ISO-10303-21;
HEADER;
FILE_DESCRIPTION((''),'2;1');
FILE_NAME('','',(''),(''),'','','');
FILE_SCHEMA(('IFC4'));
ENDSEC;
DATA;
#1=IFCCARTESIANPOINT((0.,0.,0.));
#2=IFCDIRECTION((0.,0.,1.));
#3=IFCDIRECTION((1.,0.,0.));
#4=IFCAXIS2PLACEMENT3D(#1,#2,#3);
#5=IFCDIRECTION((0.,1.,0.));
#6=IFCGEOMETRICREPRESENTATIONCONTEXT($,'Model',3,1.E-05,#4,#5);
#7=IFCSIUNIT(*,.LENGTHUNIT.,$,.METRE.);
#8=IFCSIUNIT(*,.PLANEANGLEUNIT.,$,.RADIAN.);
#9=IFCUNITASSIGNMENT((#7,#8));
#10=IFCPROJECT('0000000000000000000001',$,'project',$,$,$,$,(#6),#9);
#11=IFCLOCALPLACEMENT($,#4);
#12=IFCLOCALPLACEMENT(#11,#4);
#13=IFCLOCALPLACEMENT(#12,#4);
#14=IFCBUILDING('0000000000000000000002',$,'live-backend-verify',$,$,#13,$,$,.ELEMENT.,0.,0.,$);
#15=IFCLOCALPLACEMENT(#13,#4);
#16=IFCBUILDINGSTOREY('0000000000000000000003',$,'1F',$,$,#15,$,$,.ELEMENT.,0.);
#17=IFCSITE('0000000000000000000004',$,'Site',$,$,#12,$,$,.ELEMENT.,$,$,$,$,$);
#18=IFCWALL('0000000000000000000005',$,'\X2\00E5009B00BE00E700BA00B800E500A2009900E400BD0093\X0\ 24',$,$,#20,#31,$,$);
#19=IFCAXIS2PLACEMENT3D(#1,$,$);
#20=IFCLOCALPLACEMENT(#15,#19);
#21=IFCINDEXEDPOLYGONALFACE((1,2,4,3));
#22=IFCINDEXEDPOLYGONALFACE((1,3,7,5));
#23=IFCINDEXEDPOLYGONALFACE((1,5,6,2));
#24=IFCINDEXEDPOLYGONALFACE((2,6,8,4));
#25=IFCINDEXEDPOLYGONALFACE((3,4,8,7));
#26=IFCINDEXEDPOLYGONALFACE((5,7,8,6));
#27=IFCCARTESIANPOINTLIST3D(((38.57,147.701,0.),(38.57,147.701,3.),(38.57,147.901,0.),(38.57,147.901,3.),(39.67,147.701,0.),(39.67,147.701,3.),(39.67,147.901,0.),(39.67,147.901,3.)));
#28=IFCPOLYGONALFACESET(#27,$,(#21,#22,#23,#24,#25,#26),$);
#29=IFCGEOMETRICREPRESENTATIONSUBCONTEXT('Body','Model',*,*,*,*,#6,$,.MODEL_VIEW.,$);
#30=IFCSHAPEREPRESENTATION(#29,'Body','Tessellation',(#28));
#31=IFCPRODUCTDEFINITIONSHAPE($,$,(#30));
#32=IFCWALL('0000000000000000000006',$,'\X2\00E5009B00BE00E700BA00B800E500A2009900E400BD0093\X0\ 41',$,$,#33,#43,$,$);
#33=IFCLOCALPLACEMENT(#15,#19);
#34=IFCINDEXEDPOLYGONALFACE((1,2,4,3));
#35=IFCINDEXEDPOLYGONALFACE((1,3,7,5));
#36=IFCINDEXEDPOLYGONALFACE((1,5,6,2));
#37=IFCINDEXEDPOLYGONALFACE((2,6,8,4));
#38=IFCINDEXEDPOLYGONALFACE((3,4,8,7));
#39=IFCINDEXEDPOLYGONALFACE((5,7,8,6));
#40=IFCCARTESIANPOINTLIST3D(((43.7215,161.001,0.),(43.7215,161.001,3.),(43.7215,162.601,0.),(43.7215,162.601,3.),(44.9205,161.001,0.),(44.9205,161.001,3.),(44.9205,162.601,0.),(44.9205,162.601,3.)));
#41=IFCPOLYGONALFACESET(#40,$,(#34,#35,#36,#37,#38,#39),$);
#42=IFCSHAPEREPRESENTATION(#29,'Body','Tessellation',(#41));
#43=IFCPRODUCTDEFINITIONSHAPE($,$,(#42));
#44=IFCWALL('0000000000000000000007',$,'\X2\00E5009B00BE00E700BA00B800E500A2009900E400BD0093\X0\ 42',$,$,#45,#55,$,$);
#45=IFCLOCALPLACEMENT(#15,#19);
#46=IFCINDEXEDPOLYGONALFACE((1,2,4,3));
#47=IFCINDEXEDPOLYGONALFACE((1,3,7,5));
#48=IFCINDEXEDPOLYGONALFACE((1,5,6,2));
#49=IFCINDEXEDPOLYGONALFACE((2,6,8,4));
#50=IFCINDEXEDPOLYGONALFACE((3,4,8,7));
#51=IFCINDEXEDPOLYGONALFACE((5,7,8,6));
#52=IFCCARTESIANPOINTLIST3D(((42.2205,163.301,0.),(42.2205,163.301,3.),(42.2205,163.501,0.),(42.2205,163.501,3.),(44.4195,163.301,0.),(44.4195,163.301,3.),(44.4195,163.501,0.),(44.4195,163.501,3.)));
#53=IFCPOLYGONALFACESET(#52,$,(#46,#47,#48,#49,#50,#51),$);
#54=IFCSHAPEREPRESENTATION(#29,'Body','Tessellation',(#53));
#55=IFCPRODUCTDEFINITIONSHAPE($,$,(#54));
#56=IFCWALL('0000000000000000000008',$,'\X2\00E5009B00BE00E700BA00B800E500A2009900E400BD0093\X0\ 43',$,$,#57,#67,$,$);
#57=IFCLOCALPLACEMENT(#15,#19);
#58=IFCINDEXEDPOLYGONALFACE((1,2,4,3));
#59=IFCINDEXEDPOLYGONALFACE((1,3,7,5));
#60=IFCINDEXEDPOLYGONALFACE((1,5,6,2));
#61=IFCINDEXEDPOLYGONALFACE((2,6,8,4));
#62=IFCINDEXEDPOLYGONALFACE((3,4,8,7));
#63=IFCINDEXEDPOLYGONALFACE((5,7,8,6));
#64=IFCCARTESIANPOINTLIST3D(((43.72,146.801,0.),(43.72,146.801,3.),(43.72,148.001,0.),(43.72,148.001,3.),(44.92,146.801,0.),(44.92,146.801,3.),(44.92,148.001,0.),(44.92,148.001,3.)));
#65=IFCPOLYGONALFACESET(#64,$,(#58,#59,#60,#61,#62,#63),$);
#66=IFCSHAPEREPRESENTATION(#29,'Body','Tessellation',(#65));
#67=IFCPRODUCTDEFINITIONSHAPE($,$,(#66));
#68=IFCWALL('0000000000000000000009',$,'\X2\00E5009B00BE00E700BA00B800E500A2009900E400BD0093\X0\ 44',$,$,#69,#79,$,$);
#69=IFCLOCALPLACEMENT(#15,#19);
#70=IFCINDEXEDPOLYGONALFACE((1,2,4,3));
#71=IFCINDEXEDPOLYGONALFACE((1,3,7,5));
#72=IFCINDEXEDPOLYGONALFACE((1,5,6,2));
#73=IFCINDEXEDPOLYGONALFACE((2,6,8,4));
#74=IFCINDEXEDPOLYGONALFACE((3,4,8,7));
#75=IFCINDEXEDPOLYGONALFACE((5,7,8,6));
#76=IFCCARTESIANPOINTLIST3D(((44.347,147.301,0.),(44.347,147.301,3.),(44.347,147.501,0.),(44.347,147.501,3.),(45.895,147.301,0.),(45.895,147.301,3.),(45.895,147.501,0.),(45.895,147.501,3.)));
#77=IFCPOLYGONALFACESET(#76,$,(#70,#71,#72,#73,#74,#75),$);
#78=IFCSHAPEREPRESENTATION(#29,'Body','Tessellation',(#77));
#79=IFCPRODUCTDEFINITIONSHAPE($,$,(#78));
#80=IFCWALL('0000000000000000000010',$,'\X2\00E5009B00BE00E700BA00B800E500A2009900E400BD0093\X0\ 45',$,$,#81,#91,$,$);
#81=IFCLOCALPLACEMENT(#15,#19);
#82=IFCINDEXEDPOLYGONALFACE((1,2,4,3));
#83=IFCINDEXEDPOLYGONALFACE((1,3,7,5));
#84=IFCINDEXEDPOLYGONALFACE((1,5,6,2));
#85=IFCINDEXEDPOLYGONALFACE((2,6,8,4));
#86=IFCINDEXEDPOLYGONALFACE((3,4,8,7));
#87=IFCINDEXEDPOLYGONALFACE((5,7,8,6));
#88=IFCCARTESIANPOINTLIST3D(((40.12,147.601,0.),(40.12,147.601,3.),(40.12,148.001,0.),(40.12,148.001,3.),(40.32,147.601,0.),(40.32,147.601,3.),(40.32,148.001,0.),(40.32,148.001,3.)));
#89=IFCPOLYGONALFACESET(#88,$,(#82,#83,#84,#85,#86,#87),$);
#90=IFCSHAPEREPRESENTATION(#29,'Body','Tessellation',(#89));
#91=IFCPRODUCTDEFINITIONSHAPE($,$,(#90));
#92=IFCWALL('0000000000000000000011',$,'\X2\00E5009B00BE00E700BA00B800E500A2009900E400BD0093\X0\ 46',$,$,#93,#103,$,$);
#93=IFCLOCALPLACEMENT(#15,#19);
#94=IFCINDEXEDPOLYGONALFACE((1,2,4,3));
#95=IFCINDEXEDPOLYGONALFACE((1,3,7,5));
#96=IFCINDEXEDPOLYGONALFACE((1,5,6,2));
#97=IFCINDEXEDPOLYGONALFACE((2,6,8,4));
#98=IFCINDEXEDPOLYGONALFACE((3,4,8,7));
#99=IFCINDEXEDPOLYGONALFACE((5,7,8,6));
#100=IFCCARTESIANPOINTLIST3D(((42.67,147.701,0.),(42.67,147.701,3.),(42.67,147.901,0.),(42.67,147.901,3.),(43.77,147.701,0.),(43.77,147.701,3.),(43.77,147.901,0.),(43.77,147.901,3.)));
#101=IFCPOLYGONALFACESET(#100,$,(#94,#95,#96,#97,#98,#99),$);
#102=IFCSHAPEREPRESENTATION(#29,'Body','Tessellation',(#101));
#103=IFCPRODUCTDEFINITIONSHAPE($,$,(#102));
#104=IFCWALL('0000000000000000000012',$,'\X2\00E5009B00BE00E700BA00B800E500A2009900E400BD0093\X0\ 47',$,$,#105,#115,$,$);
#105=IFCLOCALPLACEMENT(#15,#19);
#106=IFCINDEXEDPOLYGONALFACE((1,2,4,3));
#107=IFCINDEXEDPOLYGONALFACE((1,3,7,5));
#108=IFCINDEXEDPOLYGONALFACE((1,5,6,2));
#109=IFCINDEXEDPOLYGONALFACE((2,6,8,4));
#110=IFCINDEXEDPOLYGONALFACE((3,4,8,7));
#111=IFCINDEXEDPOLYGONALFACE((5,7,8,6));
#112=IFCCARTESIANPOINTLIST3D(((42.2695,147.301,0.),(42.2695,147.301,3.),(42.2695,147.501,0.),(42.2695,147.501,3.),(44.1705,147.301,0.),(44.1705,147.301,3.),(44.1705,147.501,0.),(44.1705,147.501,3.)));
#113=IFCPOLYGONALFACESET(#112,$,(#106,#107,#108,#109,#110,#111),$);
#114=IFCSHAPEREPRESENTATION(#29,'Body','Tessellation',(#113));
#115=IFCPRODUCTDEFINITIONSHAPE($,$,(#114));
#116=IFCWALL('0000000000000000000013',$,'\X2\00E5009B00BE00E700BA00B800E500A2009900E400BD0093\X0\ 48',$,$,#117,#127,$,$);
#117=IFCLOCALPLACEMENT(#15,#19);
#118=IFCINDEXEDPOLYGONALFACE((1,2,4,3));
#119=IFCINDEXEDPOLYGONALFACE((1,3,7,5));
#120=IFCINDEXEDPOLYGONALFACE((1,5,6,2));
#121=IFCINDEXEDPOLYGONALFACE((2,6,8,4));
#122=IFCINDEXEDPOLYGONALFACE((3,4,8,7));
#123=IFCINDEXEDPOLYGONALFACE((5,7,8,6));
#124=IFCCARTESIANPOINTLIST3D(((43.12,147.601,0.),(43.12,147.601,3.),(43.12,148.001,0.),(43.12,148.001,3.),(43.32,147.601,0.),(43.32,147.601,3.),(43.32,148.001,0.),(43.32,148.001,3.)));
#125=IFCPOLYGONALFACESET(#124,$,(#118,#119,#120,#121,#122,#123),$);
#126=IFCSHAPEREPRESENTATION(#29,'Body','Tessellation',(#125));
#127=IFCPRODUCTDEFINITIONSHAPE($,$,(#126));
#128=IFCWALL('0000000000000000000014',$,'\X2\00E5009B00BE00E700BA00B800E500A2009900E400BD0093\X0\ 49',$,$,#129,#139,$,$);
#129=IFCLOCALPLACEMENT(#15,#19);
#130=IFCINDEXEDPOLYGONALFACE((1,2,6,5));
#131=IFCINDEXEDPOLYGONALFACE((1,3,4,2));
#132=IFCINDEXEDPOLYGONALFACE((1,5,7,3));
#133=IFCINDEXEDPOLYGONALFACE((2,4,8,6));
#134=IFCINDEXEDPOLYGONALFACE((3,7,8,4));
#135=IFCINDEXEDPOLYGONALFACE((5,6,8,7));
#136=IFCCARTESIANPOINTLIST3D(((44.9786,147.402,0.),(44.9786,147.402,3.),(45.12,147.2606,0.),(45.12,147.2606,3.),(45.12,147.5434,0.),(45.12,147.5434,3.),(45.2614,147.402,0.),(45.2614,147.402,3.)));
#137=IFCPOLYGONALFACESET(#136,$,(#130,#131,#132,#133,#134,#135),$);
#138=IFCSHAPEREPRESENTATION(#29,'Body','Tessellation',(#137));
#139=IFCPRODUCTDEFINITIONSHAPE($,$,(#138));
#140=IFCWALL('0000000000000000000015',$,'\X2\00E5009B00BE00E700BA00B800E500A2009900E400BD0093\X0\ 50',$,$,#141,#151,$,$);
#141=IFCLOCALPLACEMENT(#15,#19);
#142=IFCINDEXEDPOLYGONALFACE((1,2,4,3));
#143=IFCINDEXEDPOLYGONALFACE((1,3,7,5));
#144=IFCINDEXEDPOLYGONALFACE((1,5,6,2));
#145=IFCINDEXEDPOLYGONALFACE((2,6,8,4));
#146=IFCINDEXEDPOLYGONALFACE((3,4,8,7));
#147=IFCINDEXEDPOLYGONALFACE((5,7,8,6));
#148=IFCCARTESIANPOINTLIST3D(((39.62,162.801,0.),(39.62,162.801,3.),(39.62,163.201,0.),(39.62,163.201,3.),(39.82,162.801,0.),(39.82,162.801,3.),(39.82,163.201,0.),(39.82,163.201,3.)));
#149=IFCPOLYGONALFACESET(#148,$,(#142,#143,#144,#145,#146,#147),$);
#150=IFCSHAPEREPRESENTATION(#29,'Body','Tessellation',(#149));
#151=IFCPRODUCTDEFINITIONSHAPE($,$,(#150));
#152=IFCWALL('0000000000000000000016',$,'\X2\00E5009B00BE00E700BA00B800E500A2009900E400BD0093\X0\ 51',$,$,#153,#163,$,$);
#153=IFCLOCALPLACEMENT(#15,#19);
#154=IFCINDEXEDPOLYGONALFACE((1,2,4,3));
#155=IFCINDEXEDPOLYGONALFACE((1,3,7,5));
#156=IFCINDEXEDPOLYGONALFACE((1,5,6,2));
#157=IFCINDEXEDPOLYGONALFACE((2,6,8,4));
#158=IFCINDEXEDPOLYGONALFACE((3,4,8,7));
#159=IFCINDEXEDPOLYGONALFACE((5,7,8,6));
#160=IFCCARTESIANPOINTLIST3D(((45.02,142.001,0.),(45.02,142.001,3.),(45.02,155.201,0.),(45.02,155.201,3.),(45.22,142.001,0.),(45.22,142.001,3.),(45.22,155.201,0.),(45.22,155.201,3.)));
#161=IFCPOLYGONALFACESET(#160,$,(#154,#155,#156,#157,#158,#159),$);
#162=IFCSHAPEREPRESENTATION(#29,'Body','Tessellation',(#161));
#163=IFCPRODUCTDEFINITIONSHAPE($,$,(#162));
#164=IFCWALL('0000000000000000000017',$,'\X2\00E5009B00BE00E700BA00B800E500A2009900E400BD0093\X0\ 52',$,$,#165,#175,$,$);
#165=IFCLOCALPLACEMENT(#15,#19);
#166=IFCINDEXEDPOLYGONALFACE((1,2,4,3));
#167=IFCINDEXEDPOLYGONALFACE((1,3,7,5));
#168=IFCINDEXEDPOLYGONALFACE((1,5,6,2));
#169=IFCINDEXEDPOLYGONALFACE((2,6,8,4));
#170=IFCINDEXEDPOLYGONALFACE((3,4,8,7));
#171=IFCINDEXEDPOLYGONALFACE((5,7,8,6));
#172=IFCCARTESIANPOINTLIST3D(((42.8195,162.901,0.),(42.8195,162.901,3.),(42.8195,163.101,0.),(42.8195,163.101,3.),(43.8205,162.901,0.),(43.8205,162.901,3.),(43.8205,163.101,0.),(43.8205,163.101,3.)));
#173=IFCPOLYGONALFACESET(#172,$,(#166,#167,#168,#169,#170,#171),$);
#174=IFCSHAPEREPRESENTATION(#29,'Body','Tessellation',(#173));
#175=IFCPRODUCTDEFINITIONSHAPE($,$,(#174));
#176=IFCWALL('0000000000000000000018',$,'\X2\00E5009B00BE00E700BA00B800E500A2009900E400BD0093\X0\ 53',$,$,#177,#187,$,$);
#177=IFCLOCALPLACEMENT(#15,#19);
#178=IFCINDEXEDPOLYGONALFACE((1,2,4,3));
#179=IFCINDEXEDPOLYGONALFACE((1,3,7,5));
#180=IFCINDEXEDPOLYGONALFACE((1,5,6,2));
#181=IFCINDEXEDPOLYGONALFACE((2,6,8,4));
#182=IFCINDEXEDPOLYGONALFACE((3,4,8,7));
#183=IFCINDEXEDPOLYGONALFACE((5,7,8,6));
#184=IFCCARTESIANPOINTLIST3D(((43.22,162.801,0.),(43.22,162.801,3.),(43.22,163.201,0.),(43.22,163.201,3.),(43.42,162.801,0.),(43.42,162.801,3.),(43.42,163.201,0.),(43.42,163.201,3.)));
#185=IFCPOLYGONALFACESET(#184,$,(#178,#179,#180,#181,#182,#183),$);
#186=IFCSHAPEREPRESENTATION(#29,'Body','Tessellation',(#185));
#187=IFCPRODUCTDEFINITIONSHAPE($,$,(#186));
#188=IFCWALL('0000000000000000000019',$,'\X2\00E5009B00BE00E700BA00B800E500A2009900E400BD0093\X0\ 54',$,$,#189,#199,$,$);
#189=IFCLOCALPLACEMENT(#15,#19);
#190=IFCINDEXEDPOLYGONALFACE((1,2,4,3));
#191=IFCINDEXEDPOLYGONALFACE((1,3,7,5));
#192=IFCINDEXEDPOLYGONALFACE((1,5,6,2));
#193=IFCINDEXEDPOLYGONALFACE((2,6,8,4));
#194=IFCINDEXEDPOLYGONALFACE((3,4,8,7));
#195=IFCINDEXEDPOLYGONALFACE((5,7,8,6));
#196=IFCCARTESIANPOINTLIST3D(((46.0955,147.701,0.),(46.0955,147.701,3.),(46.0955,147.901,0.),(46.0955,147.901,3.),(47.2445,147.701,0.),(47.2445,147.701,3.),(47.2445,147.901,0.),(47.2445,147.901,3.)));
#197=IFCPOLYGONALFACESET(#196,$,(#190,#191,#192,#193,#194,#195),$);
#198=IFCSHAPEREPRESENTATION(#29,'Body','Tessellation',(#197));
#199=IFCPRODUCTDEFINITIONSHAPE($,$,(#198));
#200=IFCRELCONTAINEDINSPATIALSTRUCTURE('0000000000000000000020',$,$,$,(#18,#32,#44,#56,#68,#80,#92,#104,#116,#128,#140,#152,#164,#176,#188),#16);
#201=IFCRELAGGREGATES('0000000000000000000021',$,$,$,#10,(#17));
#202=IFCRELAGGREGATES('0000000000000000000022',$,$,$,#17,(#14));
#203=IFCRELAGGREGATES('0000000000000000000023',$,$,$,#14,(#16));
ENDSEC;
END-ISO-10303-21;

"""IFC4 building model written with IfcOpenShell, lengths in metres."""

from ifc_helpers import new_model, si_unit, direction, frame, frame_2d, origin_with_axes, place, context, subcontext, project, spatial, rectangle, extrude, element, save


model = new_model("IFC4")

# Units and contexts
model_context = context("Model", 3, precision=1e-05, world=origin_with_axes(), true_north=direction((0.0, 1.0, 0.0)))
body_context = subcontext(model_context, "Body", "Model", "MODEL_VIEW")
ifc_project = project(units=[si_unit("LENGTHUNIT", "METRE"), si_unit("PLANEANGLEUNIT", "RADIAN")], contexts=[model_context])

# Site, building, storey
placement = place(None, origin_with_axes())
site_placement = place(placement, origin_with_axes())
site = spatial("IfcSite", under=ifc_project, at=site_placement, Name="Site", CompositionType="ELEMENT")
building_placement = place(site_placement, origin_with_axes())
building = spatial("IfcBuilding", under=site, at=building_placement, Name="live-backend-verify", CompositionType="ELEMENT", ElevationOfRefHeight=0.0, ElevationOfTerrain=0.0)
storey_placement = place(building_placement, origin_with_axes())
storey = spatial("IfcBuildingStorey", under=building, at=storey_placement, Name="1F", CompositionType="ELEMENT", Elevation=0.0)

# Walls
wall_1_placement = place(storey_placement, frame((39.12, 147.801, 0.0), z_axis=(0.0, 0.0, 1.0), x_axis=(1.0, 0.0, 0.0)))
element("IfcWall", 1, at=wall_1_placement, inside=storey, Name="å\u009b¾çº¸å¢\u0099ä½\u0093 24", context=body_context, shape_type="SweptSolid", body=[
    extrude(rectangle(XDim=1.1, YDim=0.2, at=frame_2d((0.0, 0.0), x_axis=(1.0, 0.0, 0.0))), frame((0.0, 0.0, 0.0), z_axis=(0.0, 0.0, 1.0)), (0.0, 0.0, 1.0), 3.0),
])
wall_2_placement = place(storey_placement, frame((44.321, 161.801, 0.0), z_axis=(0.0, 0.0, 1.0), x_axis=(1.0, 0.0, 0.0)))
element("IfcWall", 2, at=wall_2_placement, inside=storey, Name="å\u009b¾çº¸å¢\u0099ä½\u0093 41", context=body_context, shape_type="SweptSolid", body=[
    extrude(rectangle(XDim=1.199, YDim=1.6, at=frame_2d((0.0, 0.0), x_axis=(1.0, 0.0, 0.0))), frame((0.0, 0.0, 0.0), z_axis=(0.0, 0.0, 1.0)), (0.0, 0.0, 1.0), 3.0),
])
wall_3_placement = place(storey_placement, frame((43.32, 163.401, 0.0), z_axis=(0.0, 0.0, 1.0), x_axis=(1.0, 0.0, 0.0)))
element("IfcWall", 3, at=wall_3_placement, inside=storey, Name="å\u009b¾çº¸å¢\u0099ä½\u0093 42", context=body_context, shape_type="SweptSolid", body=[
    extrude(rectangle(XDim=2.199, YDim=0.2, at=frame_2d((0.0, 0.0), x_axis=(1.0, 0.0, 0.0))), frame((0.0, 0.0, 0.0), z_axis=(0.0, 0.0, 1.0)), (0.0, 0.0, 1.0), 3.0),
])
wall_4_placement = place(storey_placement, frame((44.32, 147.401, 0.0), z_axis=(0.0, 0.0, 1.0), x_axis=(1.0, 0.0, 0.0)))
element("IfcWall", 4, at=wall_4_placement, inside=storey, Name="å\u009b¾çº¸å¢\u0099ä½\u0093 43", context=body_context, shape_type="SweptSolid", body=[
    extrude(rectangle(XDim=1.2, YDim=1.2, at=frame_2d((0.0, 0.0), x_axis=(1.0, 0.0, 0.0))), frame((0.0, 0.0, 0.0), z_axis=(0.0, 0.0, 1.0)), (0.0, 0.0, 1.0), 3.0),
])
wall_5_placement = place(storey_placement, frame((45.121, 147.401, 0.0), z_axis=(0.0, 0.0, 1.0), x_axis=(1.0, 0.0, 0.0)))
element("IfcWall", 5, at=wall_5_placement, inside=storey, Name="å\u009b¾çº¸å¢\u0099ä½\u0093 44", context=body_context, shape_type="SweptSolid", body=[
    extrude(rectangle(XDim=1.548, YDim=0.2, at=frame_2d((0.0, 0.0), x_axis=(1.0, 0.0, 0.0))), frame((0.0, 0.0, 0.0), z_axis=(0.0, 0.0, 1.0)), (0.0, 0.0, 1.0), 3.0),
])
wall_6_placement = place(storey_placement, frame((40.22, 147.801, 0.0), z_axis=(0.0, 0.0, 1.0), x_axis=(0.0, -1.0, 0.0)))
element("IfcWall", 6, at=wall_6_placement, inside=storey, Name="å\u009b¾çº¸å¢\u0099ä½\u0093 45", context=body_context, shape_type="SweptSolid", body=[
    extrude(rectangle(XDim=0.4, YDim=0.2, at=frame_2d((0.0, 0.0), x_axis=(1.0, 0.0, 0.0))), frame((0.0, 0.0, 0.0), z_axis=(0.0, 0.0, 1.0)), (0.0, 0.0, 1.0), 3.0),
])
wall_7_placement = place(storey_placement, frame((43.22, 147.801, 0.0), z_axis=(0.0, 0.0, 1.0), x_axis=(1.0, 0.0, 0.0)))
element("IfcWall", 7, at=wall_7_placement, inside=storey, Name="å\u009b¾çº¸å¢\u0099ä½\u0093 46", context=body_context, shape_type="SweptSolid", body=[
    extrude(rectangle(XDim=1.1, YDim=0.2, at=frame_2d((0.0, 0.0), x_axis=(1.0, 0.0, 0.0))), frame((0.0, 0.0, 0.0), z_axis=(0.0, 0.0, 1.0)), (0.0, 0.0, 1.0), 3.0),
])
wall_8_placement = place(storey_placement, frame((43.22, 147.401, 0.0), z_axis=(0.0, 0.0, 1.0), x_axis=(1.0, 0.0, 0.0)))
element("IfcWall", 8, at=wall_8_placement, inside=storey, Name="å\u009b¾çº¸å¢\u0099ä½\u0093 47", context=body_context, shape_type="SweptSolid", body=[
    extrude(rectangle(XDim=1.901, YDim=0.2, at=frame_2d((0.0, 0.0), x_axis=(1.0, 0.0, 0.0))), frame((0.0, 0.0, 0.0), z_axis=(0.0, 0.0, 1.0)), (0.0, 0.0, 1.0), 3.0),
])
wall_9_placement = place(storey_placement, frame((43.22, 147.801, 0.0), z_axis=(0.0, 0.0, 1.0), x_axis=(0.0, -1.0, 0.0)))
element("IfcWall", 9, at=wall_9_placement, inside=storey, Name="å\u009b¾çº¸å¢\u0099ä½\u0093 48", context=body_context, shape_type="SweptSolid", body=[
    extrude(rectangle(XDim=0.4, YDim=0.2, at=frame_2d((0.0, 0.0), x_axis=(1.0, 0.0, 0.0))), frame((0.0, 0.0, 0.0), z_axis=(0.0, 0.0, 1.0)), (0.0, 0.0, 1.0), 3.0),
])
wall_10_placement = place(storey_placement, frame((45.12, 147.402, 0.0), z_axis=(0.0, 0.0, 1.0), x_axis=(0.707107, -0.707107, 0.0)))
element("IfcWall", 10, at=wall_10_placement, inside=storey, Name="å\u009b¾çº¸å¢\u0099ä½\u0093 49", context=body_context, shape_type="SweptSolid", body=[
    extrude(rectangle(XDim=0.2, YDim=0.2, at=frame_2d((0.0, 0.0), x_axis=(1.0, 0.0, 0.0))), frame((0.0, 0.0, 0.0), z_axis=(0.0, 0.0, 1.0)), (0.0, 0.0, 1.0), 3.0),
])
wall_11_placement = place(storey_placement, frame((39.72, 163.001, 0.0), z_axis=(0.0, 0.0, 1.0), x_axis=(0.0, 1.0, 0.0)))
element("IfcWall", 11, at=wall_11_placement, inside=storey, Name="å\u009b¾çº¸å¢\u0099ä½\u0093 50", context=body_context, shape_type="SweptSolid", body=[
    extrude(rectangle(XDim=0.4, YDim=0.2, at=frame_2d((0.0, 0.0), x_axis=(1.0, 0.0, 0.0))), frame((0.0, 0.0, 0.0), z_axis=(0.0, 0.0, 1.0)), (0.0, 0.0, 1.0), 3.0),
])
wall_12_placement = place(storey_placement, frame((45.12, 148.601, 0.0), z_axis=(0.0, 0.0, 1.0), x_axis=(0.0, 1.0, 0.0)))
element("IfcWall", 12, at=wall_12_placement, inside=storey, Name="å\u009b¾çº¸å¢\u0099ä½\u0093 51", context=body_context, shape_type="SweptSolid", body=[
    extrude(rectangle(XDim=13.2, YDim=0.2, at=frame_2d((0.0, 0.0), x_axis=(1.0, 0.0, 0.0))), frame((0.0, 0.0, 0.0), z_axis=(0.0, 0.0, 1.0)), (0.0, 0.0, 1.0), 3.0),
])
wall_13_placement = place(storey_placement, frame((43.32, 163.001, 0.0), z_axis=(0.0, 0.0, 1.0), x_axis=(1.0, 0.0, 0.0)))
element("IfcWall", 13, at=wall_13_placement, inside=storey, Name="å\u009b¾çº¸å¢\u0099ä½\u0093 52", context=body_context, shape_type="SweptSolid", body=[
    extrude(rectangle(XDim=1.001, YDim=0.2, at=frame_2d((0.0, 0.0), x_axis=(1.0, 0.0, 0.0))), frame((0.0, 0.0, 0.0), z_axis=(0.0, 0.0, 1.0)), (0.0, 0.0, 1.0), 3.0),
])
wall_14_placement = place(storey_placement, frame((43.32, 163.001, 0.0), z_axis=(0.0, 0.0, 1.0), x_axis=(0.0, 1.0, 0.0)))
element("IfcWall", 14, at=wall_14_placement, inside=storey, Name="å\u009b¾çº¸å¢\u0099ä½\u0093 53", context=body_context, shape_type="SweptSolid", body=[
    extrude(rectangle(XDim=0.4, YDim=0.2, at=frame_2d((0.0, 0.0), x_axis=(1.0, 0.0, 0.0))), frame((0.0, 0.0, 0.0), z_axis=(0.0, 0.0, 1.0)), (0.0, 0.0, 1.0), 3.0),
])
wall_15_placement = place(storey_placement, frame((46.67, 147.801, 0.0), z_axis=(0.0, 0.0, 1.0), x_axis=(-1.0, 0.0, 0.0)))
element("IfcWall", 15, at=wall_15_placement, inside=storey, Name="å\u009b¾çº¸å¢\u0099ä½\u0093 54", context=body_context, shape_type="SweptSolid", body=[
    extrude(rectangle(XDim=1.149, YDim=0.2, at=frame_2d((0.0, 0.0), x_axis=(1.0, 0.0, 0.0))), frame((0.0, 0.0, 0.0), z_axis=(0.0, 0.0, 1.0)), (0.0, 0.0, 1.0), 3.0),
])

save(model, "model.ifc")
